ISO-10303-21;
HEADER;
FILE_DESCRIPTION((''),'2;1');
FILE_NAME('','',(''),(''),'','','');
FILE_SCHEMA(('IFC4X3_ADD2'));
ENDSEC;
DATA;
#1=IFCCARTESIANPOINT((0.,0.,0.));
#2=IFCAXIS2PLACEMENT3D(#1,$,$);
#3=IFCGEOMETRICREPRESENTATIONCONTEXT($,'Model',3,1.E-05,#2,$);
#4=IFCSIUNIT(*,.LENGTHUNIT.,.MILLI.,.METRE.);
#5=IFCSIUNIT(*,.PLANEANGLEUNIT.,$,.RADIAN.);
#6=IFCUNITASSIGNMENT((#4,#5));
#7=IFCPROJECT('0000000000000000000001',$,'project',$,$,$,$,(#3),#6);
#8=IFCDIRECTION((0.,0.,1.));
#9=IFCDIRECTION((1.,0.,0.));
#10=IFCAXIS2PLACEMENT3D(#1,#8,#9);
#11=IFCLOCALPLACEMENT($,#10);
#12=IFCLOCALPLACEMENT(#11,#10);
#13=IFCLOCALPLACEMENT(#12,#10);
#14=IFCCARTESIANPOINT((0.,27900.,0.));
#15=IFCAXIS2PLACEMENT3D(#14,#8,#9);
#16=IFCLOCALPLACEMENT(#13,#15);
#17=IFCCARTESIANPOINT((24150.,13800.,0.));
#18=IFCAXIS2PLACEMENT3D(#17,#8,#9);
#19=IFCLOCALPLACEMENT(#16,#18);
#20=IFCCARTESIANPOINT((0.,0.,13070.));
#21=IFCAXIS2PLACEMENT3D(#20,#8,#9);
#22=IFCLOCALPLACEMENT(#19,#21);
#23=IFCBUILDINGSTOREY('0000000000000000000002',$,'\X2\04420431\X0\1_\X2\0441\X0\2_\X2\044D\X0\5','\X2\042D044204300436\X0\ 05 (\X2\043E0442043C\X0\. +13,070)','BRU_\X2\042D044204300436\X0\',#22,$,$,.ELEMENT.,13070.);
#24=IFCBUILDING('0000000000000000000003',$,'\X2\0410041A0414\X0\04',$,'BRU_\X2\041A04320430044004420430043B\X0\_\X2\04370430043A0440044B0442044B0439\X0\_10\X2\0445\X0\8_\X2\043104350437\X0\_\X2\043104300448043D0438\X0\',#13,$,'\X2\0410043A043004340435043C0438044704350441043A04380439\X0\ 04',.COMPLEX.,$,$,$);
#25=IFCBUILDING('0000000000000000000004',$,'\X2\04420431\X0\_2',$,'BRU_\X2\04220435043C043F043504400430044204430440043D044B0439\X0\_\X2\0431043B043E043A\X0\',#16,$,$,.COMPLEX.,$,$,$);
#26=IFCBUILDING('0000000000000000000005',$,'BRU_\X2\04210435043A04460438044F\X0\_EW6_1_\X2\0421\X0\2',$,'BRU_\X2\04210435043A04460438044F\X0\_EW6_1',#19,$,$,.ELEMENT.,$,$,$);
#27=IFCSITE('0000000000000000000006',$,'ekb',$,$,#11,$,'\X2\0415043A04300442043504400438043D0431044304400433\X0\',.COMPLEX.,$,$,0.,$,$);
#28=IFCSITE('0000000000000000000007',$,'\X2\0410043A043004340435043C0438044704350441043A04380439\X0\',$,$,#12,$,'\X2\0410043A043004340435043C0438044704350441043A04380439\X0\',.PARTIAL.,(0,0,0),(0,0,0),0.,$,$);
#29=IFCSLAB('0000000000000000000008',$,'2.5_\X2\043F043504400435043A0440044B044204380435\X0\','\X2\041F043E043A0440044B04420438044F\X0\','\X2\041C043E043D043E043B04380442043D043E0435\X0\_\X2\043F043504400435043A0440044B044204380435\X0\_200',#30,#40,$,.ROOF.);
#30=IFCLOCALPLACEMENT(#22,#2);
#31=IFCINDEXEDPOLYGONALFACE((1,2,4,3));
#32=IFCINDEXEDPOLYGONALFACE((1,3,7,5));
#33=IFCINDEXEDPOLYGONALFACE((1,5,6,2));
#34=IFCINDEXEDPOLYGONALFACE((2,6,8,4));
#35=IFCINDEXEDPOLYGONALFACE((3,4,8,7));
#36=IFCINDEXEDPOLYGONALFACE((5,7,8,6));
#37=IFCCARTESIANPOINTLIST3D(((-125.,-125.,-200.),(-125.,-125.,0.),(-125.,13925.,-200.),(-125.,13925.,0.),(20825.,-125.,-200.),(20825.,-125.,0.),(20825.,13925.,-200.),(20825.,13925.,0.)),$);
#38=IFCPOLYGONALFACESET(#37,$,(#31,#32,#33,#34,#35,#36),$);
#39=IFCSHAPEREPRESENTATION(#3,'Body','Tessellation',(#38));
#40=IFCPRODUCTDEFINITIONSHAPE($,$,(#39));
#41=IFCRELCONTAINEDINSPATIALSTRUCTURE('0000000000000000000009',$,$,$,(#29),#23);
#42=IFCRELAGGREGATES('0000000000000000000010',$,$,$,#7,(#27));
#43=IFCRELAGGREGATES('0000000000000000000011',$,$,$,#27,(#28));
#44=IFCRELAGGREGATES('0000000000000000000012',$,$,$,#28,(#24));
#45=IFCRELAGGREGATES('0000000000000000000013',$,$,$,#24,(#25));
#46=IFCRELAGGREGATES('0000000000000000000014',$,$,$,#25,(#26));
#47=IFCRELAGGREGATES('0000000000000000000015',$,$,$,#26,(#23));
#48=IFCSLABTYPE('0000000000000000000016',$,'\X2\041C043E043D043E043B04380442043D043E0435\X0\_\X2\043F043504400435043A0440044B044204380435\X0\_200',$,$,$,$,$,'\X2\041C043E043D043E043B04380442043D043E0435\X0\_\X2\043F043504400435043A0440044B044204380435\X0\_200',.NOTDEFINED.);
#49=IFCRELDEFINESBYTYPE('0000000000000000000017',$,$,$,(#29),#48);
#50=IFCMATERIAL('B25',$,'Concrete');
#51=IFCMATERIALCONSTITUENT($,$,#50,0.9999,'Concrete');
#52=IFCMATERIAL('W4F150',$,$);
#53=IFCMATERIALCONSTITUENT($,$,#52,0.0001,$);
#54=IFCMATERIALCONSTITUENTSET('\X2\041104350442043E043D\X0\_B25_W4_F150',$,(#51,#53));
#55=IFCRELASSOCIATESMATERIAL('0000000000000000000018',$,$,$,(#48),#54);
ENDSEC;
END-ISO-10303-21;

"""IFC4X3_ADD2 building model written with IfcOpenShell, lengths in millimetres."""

from ifc_helpers import new_model, si_unit, frame, origin, origin_with_axes, place, context, project, spatial, polyline, outline, extrude, material, constituent, constituent_set, type_object, element, save


model = new_model("IFC4X3_ADD2")

# Units and contexts
model_context = context("Model", 3, precision=1e-05, world=origin())
ifc_project = project(units=[si_unit("LENGTHUNIT", "METRE", prefix="MILLI"), si_unit("PLANEANGLEUNIT", "RADIAN")], contexts=[model_context])

# Sites, buildings, storey
site_1_placement = place(None, origin_with_axes())
site_1 = spatial("IfcSite", under=ifc_project, at=site_1_placement, Name="ekb", LongName="Екатеринбург", CompositionType="COMPLEX", RefElevation=0.0)
site_2_placement = place(site_1_placement, origin_with_axes())
site_2 = spatial("IfcSite", under=site_1, at=site_2_placement, Name="Академический", LongName="Академический", CompositionType="PARTIAL", RefLatitude=(0, 0, 0), RefLongitude=(0, 0, 0), RefElevation=0.0)
building_1_placement = place(site_2_placement, origin_with_axes())
building_1 = spatial("IfcBuilding", under=site_2, at=building_1_placement, Name="АКД04", ObjectType="BRU_Квартал_закрытый_10х8_без_башни", LongName="Академический 04", CompositionType="COMPLEX")
building_2_placement = place(building_1_placement, frame((0.0, 27900.0, 0.0), z_axis=(0.0, 0.0, 1.0), x_axis=(1.0, 0.0, 0.0)))
building_2 = spatial("IfcBuilding", under=building_1, at=building_2_placement, Name="тб_2", ObjectType="BRU_Температурный_блок", CompositionType="COMPLEX")
building_3_placement = place(building_2_placement, frame((24150.0, 13800.0, 0.0), z_axis=(0.0, 0.0, 1.0), x_axis=(1.0, 0.0, 0.0)))
building_3 = spatial("IfcBuilding", under=building_2, at=building_3_placement, Name="BRU_Секция_EW6_1_С2", ObjectType="BRU_Секция_EW6_1", CompositionType="ELEMENT")
storey_placement = place(building_3_placement, frame((0.0, 0.0, 13070.0), z_axis=(0.0, 0.0, 1.0), x_axis=(1.0, 0.0, 0.0)))
storey = spatial("IfcBuildingStorey", under=building_3, at=storey_placement, Name="тб1_с2_э5", Description="Этаж 05 (отм. +13,070)", ObjectType="BRU_Этаж", CompositionType="ELEMENT", Elevation=13070.0)

# Shared definitions
ifc_material_1 = material(Name="B25", Category="Concrete")
ifc_material_2 = material(Name="W4F150")

# Slab
ifc_constituent_1 = constituent(ifc_material_1, Category="Concrete", fraction=0.9999)
ifc_constituent_2 = constituent(ifc_material_2, fraction=0.0001)
ifc_constituent_set_1 = constituent_set(constituents=[ifc_constituent_1, ifc_constituent_2], Name="Бетон_B25_W4_F150")
slab_type = type_object("IfcSlabType", Name="Монолитное_перекрытие_200", ElementType="Монолитное_перекрытие_200", PredefinedType="NOTDEFINED", material=ifc_constituent_set_1)
slab_placement = place(storey_placement, frame((0.0, 0.0, -200.0), z_axis=(0.0, 0.0, 1.0), x_axis=(1.0, 0.0, 0.0)))
element("IfcSlab", 1, at=slab_placement, inside=storey, type_object=slab_type, Name="2.5_перекрытие", Description="Покрытия", ObjectType="Монолитное_перекрытие_200", PredefinedType="ROOF", context=model_context, shape_type="SweptSolid", body=[
    extrude(outline(polyline([(-125.0, -125.0), (20825.0, -125.0), (20825.0, 13925.0), (-125.0, 13925.0), (-125.0, -125.0)])), origin_with_axes(), (0.0, 0.0, 1.0), 200.0),
])

save(model, "model.ifc")
